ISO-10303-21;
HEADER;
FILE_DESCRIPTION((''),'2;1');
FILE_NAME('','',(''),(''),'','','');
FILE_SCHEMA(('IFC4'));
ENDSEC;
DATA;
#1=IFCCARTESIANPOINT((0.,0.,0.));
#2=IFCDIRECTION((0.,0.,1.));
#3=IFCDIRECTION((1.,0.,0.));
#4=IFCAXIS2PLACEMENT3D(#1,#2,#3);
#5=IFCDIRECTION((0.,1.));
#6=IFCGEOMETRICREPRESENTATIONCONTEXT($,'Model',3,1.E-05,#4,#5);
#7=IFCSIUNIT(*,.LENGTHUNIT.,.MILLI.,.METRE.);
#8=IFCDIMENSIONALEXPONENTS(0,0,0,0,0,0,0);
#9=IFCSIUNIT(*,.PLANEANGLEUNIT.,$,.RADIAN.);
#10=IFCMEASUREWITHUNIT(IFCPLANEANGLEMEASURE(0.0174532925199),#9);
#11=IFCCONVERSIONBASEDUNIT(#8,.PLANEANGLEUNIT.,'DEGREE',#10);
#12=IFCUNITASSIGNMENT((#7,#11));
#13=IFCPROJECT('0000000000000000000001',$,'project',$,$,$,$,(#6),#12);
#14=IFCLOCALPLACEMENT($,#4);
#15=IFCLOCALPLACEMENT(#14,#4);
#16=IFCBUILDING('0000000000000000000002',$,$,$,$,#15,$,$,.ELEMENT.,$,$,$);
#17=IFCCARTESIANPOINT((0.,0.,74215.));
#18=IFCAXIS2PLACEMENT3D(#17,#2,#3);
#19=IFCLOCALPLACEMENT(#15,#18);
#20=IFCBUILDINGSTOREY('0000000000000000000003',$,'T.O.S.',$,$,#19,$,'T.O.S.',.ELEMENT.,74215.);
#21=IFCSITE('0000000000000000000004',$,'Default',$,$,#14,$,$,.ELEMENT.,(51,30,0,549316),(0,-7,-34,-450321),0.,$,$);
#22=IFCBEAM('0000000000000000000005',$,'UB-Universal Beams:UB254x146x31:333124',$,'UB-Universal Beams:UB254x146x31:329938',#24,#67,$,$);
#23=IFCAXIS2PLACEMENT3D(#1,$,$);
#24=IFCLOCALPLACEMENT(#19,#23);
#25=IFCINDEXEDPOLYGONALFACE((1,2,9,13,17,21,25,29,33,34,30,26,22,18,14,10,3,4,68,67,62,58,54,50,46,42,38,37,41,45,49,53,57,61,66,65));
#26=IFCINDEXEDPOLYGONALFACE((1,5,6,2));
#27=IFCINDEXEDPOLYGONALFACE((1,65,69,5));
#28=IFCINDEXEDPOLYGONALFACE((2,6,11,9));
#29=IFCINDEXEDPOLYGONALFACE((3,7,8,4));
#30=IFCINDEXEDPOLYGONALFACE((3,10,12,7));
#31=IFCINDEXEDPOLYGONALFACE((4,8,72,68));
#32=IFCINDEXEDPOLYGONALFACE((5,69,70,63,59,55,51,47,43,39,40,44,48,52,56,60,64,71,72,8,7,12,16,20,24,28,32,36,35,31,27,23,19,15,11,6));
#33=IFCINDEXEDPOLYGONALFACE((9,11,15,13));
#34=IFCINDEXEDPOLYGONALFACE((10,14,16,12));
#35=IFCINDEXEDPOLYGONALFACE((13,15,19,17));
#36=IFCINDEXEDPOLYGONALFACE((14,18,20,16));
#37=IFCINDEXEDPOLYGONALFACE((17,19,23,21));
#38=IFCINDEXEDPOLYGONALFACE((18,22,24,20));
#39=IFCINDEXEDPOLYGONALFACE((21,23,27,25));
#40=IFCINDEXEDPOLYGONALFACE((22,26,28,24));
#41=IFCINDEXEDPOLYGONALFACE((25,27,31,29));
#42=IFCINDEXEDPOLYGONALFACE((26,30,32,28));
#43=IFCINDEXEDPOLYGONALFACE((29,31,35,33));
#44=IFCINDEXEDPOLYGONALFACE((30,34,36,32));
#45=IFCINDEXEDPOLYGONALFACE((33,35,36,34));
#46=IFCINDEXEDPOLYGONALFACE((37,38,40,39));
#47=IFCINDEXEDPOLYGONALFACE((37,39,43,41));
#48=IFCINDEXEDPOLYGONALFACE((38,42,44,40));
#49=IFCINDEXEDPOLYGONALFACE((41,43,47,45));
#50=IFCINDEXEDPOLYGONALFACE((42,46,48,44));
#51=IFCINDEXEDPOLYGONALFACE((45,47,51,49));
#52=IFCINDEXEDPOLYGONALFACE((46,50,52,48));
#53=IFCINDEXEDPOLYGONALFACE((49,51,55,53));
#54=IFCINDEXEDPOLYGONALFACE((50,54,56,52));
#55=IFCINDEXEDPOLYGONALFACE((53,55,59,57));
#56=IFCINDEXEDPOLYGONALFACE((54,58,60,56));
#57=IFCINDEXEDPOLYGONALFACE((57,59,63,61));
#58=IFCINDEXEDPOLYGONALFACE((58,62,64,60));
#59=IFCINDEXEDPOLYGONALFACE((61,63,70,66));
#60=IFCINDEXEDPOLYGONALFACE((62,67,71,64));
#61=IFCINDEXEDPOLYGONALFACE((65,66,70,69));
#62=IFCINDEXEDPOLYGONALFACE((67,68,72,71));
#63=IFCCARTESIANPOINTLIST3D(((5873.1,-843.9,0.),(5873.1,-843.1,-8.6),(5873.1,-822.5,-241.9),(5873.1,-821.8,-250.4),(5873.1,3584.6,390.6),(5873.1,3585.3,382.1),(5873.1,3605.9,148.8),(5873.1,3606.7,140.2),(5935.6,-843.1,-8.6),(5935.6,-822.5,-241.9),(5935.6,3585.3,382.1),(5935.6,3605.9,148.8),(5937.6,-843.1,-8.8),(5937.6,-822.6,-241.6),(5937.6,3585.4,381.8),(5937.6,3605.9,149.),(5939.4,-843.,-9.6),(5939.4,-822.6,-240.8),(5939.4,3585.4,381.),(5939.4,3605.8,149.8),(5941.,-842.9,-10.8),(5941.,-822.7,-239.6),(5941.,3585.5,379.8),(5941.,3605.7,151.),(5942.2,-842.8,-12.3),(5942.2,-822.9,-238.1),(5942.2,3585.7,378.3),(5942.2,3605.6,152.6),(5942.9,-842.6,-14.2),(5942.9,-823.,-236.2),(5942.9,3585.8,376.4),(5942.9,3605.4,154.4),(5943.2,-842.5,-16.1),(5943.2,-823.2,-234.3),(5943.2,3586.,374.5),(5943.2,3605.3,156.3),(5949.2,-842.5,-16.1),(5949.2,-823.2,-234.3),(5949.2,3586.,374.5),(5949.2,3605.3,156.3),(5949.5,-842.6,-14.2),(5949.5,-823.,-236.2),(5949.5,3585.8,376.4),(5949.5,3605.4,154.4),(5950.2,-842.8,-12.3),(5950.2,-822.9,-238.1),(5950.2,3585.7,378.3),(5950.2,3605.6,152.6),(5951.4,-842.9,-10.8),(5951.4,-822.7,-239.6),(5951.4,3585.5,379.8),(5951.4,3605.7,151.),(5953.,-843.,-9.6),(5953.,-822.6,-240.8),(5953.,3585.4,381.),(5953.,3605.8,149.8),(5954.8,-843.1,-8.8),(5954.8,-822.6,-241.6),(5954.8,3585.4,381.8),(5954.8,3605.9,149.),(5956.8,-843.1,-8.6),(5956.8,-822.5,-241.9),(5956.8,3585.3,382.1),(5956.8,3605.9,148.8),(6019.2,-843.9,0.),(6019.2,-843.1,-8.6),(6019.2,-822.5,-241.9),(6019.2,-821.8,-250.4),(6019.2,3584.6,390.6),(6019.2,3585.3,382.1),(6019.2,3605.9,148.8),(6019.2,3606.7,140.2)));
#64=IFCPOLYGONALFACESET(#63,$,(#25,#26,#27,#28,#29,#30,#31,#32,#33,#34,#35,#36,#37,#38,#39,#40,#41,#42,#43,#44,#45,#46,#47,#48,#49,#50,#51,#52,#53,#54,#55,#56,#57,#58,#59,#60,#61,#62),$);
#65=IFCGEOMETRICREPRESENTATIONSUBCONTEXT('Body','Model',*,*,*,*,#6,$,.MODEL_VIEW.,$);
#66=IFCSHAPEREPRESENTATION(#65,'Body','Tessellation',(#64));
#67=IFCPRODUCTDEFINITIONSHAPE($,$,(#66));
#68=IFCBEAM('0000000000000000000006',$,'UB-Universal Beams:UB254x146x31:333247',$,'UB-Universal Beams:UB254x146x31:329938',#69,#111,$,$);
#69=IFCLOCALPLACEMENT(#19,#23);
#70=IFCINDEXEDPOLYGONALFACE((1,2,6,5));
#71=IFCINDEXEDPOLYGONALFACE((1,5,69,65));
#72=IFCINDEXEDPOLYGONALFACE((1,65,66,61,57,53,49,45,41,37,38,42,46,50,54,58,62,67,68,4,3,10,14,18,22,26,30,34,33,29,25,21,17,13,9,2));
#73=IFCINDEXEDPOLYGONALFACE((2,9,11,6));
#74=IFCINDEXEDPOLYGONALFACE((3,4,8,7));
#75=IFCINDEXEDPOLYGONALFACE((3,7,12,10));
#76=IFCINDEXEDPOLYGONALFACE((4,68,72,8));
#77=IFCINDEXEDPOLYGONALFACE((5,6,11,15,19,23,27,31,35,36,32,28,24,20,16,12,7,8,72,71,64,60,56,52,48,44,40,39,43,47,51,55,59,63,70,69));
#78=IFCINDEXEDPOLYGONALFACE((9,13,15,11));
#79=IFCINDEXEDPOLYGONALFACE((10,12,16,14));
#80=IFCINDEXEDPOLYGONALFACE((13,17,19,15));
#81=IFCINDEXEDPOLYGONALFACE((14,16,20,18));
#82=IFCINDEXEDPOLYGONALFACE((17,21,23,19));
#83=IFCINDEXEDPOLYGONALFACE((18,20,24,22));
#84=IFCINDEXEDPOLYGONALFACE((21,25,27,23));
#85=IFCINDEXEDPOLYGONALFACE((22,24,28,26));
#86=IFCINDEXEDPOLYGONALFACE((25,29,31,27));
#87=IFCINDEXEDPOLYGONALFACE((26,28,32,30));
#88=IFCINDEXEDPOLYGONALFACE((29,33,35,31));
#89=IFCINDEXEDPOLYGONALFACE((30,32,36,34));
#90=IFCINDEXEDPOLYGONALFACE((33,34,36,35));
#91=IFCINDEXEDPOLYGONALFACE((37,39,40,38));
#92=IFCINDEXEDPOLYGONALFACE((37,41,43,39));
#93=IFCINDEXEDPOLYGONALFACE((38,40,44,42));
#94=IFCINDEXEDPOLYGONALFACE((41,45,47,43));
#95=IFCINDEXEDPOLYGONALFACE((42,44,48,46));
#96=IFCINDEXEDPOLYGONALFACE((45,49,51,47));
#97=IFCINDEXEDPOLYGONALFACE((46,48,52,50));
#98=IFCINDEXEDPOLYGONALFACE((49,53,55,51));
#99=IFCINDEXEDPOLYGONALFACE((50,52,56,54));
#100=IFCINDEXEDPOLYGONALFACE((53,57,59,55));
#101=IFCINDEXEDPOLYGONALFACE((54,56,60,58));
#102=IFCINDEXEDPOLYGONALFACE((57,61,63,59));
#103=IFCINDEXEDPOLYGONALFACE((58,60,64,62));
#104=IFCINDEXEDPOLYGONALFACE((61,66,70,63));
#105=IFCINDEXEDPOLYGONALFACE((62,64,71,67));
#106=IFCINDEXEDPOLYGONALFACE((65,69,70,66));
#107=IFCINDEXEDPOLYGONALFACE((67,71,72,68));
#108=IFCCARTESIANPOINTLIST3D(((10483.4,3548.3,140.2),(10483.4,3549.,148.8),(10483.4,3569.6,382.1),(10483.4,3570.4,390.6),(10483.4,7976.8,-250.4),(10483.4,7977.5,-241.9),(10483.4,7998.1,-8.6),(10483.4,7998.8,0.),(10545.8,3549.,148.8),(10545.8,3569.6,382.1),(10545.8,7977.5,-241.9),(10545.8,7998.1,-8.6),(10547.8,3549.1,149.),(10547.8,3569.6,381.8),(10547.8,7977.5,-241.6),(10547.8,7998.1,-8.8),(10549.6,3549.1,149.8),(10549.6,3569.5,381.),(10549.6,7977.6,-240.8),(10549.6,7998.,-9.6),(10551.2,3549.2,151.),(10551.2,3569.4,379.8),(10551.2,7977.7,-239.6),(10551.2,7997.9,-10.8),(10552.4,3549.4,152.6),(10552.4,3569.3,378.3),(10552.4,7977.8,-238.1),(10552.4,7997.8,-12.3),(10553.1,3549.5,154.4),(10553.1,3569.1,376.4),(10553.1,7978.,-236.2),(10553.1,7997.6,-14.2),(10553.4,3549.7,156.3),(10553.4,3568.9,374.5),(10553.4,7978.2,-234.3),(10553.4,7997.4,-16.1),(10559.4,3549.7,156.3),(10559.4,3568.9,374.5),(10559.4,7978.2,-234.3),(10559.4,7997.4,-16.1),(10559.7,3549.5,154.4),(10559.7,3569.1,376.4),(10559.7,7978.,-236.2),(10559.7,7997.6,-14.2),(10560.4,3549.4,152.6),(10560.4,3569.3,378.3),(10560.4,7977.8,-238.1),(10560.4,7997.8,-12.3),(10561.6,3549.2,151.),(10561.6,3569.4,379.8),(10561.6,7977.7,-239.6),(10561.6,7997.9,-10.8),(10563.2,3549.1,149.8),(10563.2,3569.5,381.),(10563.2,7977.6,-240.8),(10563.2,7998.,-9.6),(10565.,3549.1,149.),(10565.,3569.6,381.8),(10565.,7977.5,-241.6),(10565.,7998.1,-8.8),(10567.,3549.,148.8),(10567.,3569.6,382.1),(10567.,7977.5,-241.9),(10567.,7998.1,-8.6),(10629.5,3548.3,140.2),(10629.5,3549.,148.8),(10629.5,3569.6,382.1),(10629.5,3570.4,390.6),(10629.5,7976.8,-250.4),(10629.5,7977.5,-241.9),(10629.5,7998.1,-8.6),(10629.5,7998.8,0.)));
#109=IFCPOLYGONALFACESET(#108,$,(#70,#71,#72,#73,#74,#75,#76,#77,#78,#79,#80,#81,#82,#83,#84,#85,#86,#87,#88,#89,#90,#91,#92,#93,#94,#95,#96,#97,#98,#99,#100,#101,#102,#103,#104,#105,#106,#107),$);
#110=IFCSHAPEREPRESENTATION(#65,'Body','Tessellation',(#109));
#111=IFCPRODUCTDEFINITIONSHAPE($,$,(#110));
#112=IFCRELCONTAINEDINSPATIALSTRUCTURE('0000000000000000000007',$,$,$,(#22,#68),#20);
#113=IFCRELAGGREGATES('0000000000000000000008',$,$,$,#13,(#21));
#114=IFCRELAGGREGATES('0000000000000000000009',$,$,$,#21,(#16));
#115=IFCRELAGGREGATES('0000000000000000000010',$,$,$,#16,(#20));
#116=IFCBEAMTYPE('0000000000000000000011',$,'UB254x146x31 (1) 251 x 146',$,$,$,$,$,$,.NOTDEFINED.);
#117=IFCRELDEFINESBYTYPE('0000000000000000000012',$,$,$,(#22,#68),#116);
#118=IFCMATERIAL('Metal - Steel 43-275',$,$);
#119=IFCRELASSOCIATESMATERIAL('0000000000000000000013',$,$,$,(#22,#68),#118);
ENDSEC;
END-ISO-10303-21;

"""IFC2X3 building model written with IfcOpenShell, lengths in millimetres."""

from ifc_helpers import new_model, entity, si_unit, converted_unit, point, direction, frame, frame_2d, origin_with_axes, place, context, subcontext, project, spatial, polyline, circle_curve, parameter, trimmed, segment, composite_curve, outline, extrude, clip, halfspace, material, type_object, element, save


model = new_model("IFC2X3")

# Units and contexts
model_context = context("Model", 3, precision=1e-05, world=origin_with_axes(), true_north=direction((0.0, 1.0)))
body_context = subcontext(model_context, "Body", "Model", "MODEL_VIEW")
ifc_project = project(units=[si_unit("LENGTHUNIT", "METRE", prefix="MILLI"), converted_unit("PLANEANGLEUNIT", "DEGREE", entity("IfcPlaneAngleMeasure", 0.0174532925199), si_unit("PLANEANGLEUNIT", "RADIAN"), dimensions=[0, 0, 0, 0, 0, 0, 0])], contexts=[model_context])

# Site, building, storey
site_placement = place(None, origin_with_axes())
site = spatial("IfcSite", under=ifc_project, at=site_placement, Name="Default", CompositionType="ELEMENT", RefLatitude=(51, 30, 0, 549316), RefLongitude=(0, -7, -34, -450321), RefElevation=0.0)
building_placement = place(site_placement, origin_with_axes())
building = spatial("IfcBuilding", under=site, at=building_placement, CompositionType="ELEMENT")
storey_placement = place(building_placement, frame((0.0, 0.0, 74215.0), z_axis=(0.0, 0.0, 1.0), x_axis=(1.0, 0.0, 0.0)))
storey = spatial("IfcBuildingStorey", under=building, at=storey_placement, Name="T.O.S.", LongName="T.O.S.", CompositionType="ELEMENT", Elevation=74215.0)

# Beams
ifc_material = material(Name="Metal - Steel 43-275")
beam_type_1 = type_object("IfcBeamType", Name="UB254x146x31 (1) 251 x 146", PredefinedType="NOTDEFINED")
beam_1_placement = place(storey_placement, frame((5946.2, 3613.8, 267.0), z_axis=(0.0, 0.0, 1.0), x_axis=(-1.0, 0.0, 0.0)))
element("IfcBeam", 1, at=beam_1_placement, inside=storey, type_object=beam_type_1, material=ifc_material, Name="UB-Universal Beams:UB254x146x31:333124", ObjectType="UB-Universal Beams:UB254x146x31:329938", context=body_context, shape_type="Clipping", body=[
    clip(clip(clip(clip(extrude(outline(composite_curve([segment(polyline([(125.7, 73.0), (117.1, 73.0), (117.1, 10.6)]), True, "CONTINUOUS"), segment(trimmed(circle_curve(frame_2d((109.5, 10.6), x_axis=(0.0, -1.0)), 7.6), [point((117.1, 10.6)), parameter(90.0)], [point((109.5, 3.0)), parameter(0.0)], False, "CARTESIAN"), True, "CONTINUOUS"), segment(polyline([(109.5, 3.0), (-109.5, 3.0)]), True, "CONTINUOUS"), segment(trimmed(circle_curve(frame_2d((-109.5, 10.6), x_axis=(-1.0, 0.0)), 7.6), [point((-109.5, 3.0)), parameter(90.0)], [point((-117.1, 10.6)), parameter(0.0)], False, "CARTESIAN"), True, "CONTINUOUS"), segment(polyline([(-117.1, 10.6), (-117.1, 73.0), (-125.7, 73.0), (-125.7, -73.0), (-117.1, -73.0), (-117.1, -10.6)]), True, "CONTINUOUS"), segment(trimmed(circle_curve(frame_2d((-109.5, -10.6), x_axis=(0.0, 1.0)), 7.6), [point((-117.1, -10.6)), parameter(90.0)], [point((-109.5, -3.0)), parameter(0.0)], False, "CARTESIAN"), True, "CONTINUOUS"), segment(polyline([(-109.5, -3.0), (109.5, -3.0)]), True, "CONTINUOUS"), segment(trimmed(circle_curve(frame_2d((109.5, -10.6), x_axis=(1.0, 0.0)), 7.6), [point((109.5, -3.0)), parameter(90.0)], [point((117.1, -10.6)), parameter(0.0)], False, "CARTESIAN"), True, "CONTINUOUS"), segment(polyline([(117.1, -10.6), (117.1, -73.0), (125.7, -73.0), (125.7, 73.0)]), True, "CONTINUOUS")], self_intersect=False)), frame((0.0, 4482.9, -395.4), z_axis=(0.0, -0.996132, 0.087866), x_axis=(0.0, -0.087866, -0.996132)), (0.0, 0.0, 1.0), 4518.6), halfspace(frame((0.0, 4446.6, -392.2), z_axis=(0.0, -0.996132, 0.087866), x_axis=(0.0, -0.087866, -0.996132)), True)), halfspace(frame((0.0, 18.2, -1.6), z_axis=(0.0, 0.996132, -0.087866), x_axis=(0.0, 0.087866, 0.996132)), True)), halfspace(frame((0.0, 4464.8, 0.0), z_axis=(0.0, -1.0, 0.0), x_axis=(0.0, 0.0, -1.0)), True)), halfspace(frame((0.0, 0.0, 0.0), z_axis=(0.0, 1.0, 0.0), x_axis=(0.0, 0.0, 1.0)), True)),
])
beam_2_placement = place(storey_placement, frame((10556.4, 3541.2, 267.0), z_axis=(0.0, 0.0, 1.0), x_axis=(1.0, 0.0, 0.0)))
element("IfcBeam", 2, at=beam_2_placement, inside=storey, type_object=beam_type_1, material=ifc_material, Name="UB-Universal Beams:UB254x146x31:333247", ObjectType="UB-Universal Beams:UB254x146x31:329938", context=body_context, shape_type="Clipping", body=[
    clip(clip(clip(clip(extrude(outline(composite_curve([segment(polyline([(125.7, 73.0), (117.1, 73.0), (117.1, 10.6)]), True, "CONTINUOUS"), segment(trimmed(circle_curve(frame_2d((109.5, 10.6), x_axis=(0.0, -1.0)), 7.6), [point((117.1, 10.6)), parameter(90.0)], [point((109.5, 3.0)), parameter(0.0)], False, "CARTESIAN"), True, "CONTINUOUS"), segment(polyline([(109.5, 3.0), (-109.5, 3.0)]), True, "CONTINUOUS"), segment(trimmed(circle_curve(frame_2d((-109.5, 10.6), x_axis=(-1.0, 0.0)), 7.6), [point((-109.5, 3.0)), parameter(90.0)], [point((-117.1, 10.6)), parameter(0.0)], False, "CARTESIAN"), True, "CONTINUOUS"), segment(polyline([(-117.1, 10.6), (-117.1, 73.0), (-125.7, 73.0), (-125.7, -73.0), (-117.1, -73.0), (-117.1, -10.6)]), True, "CONTINUOUS"), segment(trimmed(circle_curve(frame_2d((-109.5, -10.6), x_axis=(0.0, 1.0)), 7.6), [point((-117.1, -10.6)), parameter(90.0)], [point((-109.5, -3.0)), parameter(0.0)], False, "CARTESIAN"), True, "CONTINUOUS"), segment(polyline([(-109.5, -3.0), (109.5, -3.0)]), True, "CONTINUOUS"), segment(trimmed(circle_curve(frame_2d((109.5, -10.6), x_axis=(1.0, 0.0)), 7.6), [point((109.5, -3.0)), parameter(90.0)], [point((117.1, -10.6)), parameter(0.0)], False, "CARTESIAN"), True, "CONTINUOUS"), segment(polyline([(117.1, -10.6), (117.1, -73.0), (125.7, -73.0), (125.7, 73.0)]), True, "CONTINUOUS")], self_intersect=False)), frame((0.0, 4482.9, -395.4), z_axis=(0.0, -0.996132, 0.087866), x_axis=(0.0, -0.087866, -0.996132)), (0.0, 0.0, 1.0), 4518.6), halfspace(frame((0.0, 4446.6, -392.2), z_axis=(0.0, -0.996132, 0.087866), x_axis=(0.0, -0.087866, -0.996132)), True)), halfspace(frame((0.0, 18.2, -1.6), z_axis=(0.0, 0.996132, -0.087866), x_axis=(0.0, 0.087866, 0.996132)), True)), halfspace(frame((0.0, 4464.8, 0.0), z_axis=(0.0, -1.0, 0.0), x_axis=(0.0, 0.0, -1.0)), True)), halfspace(frame((0.0, 0.0, 0.0), z_axis=(0.0, 1.0, 0.0), x_axis=(0.0, 0.0, 1.0)), True)),
])

save(model, "model.ifc")
